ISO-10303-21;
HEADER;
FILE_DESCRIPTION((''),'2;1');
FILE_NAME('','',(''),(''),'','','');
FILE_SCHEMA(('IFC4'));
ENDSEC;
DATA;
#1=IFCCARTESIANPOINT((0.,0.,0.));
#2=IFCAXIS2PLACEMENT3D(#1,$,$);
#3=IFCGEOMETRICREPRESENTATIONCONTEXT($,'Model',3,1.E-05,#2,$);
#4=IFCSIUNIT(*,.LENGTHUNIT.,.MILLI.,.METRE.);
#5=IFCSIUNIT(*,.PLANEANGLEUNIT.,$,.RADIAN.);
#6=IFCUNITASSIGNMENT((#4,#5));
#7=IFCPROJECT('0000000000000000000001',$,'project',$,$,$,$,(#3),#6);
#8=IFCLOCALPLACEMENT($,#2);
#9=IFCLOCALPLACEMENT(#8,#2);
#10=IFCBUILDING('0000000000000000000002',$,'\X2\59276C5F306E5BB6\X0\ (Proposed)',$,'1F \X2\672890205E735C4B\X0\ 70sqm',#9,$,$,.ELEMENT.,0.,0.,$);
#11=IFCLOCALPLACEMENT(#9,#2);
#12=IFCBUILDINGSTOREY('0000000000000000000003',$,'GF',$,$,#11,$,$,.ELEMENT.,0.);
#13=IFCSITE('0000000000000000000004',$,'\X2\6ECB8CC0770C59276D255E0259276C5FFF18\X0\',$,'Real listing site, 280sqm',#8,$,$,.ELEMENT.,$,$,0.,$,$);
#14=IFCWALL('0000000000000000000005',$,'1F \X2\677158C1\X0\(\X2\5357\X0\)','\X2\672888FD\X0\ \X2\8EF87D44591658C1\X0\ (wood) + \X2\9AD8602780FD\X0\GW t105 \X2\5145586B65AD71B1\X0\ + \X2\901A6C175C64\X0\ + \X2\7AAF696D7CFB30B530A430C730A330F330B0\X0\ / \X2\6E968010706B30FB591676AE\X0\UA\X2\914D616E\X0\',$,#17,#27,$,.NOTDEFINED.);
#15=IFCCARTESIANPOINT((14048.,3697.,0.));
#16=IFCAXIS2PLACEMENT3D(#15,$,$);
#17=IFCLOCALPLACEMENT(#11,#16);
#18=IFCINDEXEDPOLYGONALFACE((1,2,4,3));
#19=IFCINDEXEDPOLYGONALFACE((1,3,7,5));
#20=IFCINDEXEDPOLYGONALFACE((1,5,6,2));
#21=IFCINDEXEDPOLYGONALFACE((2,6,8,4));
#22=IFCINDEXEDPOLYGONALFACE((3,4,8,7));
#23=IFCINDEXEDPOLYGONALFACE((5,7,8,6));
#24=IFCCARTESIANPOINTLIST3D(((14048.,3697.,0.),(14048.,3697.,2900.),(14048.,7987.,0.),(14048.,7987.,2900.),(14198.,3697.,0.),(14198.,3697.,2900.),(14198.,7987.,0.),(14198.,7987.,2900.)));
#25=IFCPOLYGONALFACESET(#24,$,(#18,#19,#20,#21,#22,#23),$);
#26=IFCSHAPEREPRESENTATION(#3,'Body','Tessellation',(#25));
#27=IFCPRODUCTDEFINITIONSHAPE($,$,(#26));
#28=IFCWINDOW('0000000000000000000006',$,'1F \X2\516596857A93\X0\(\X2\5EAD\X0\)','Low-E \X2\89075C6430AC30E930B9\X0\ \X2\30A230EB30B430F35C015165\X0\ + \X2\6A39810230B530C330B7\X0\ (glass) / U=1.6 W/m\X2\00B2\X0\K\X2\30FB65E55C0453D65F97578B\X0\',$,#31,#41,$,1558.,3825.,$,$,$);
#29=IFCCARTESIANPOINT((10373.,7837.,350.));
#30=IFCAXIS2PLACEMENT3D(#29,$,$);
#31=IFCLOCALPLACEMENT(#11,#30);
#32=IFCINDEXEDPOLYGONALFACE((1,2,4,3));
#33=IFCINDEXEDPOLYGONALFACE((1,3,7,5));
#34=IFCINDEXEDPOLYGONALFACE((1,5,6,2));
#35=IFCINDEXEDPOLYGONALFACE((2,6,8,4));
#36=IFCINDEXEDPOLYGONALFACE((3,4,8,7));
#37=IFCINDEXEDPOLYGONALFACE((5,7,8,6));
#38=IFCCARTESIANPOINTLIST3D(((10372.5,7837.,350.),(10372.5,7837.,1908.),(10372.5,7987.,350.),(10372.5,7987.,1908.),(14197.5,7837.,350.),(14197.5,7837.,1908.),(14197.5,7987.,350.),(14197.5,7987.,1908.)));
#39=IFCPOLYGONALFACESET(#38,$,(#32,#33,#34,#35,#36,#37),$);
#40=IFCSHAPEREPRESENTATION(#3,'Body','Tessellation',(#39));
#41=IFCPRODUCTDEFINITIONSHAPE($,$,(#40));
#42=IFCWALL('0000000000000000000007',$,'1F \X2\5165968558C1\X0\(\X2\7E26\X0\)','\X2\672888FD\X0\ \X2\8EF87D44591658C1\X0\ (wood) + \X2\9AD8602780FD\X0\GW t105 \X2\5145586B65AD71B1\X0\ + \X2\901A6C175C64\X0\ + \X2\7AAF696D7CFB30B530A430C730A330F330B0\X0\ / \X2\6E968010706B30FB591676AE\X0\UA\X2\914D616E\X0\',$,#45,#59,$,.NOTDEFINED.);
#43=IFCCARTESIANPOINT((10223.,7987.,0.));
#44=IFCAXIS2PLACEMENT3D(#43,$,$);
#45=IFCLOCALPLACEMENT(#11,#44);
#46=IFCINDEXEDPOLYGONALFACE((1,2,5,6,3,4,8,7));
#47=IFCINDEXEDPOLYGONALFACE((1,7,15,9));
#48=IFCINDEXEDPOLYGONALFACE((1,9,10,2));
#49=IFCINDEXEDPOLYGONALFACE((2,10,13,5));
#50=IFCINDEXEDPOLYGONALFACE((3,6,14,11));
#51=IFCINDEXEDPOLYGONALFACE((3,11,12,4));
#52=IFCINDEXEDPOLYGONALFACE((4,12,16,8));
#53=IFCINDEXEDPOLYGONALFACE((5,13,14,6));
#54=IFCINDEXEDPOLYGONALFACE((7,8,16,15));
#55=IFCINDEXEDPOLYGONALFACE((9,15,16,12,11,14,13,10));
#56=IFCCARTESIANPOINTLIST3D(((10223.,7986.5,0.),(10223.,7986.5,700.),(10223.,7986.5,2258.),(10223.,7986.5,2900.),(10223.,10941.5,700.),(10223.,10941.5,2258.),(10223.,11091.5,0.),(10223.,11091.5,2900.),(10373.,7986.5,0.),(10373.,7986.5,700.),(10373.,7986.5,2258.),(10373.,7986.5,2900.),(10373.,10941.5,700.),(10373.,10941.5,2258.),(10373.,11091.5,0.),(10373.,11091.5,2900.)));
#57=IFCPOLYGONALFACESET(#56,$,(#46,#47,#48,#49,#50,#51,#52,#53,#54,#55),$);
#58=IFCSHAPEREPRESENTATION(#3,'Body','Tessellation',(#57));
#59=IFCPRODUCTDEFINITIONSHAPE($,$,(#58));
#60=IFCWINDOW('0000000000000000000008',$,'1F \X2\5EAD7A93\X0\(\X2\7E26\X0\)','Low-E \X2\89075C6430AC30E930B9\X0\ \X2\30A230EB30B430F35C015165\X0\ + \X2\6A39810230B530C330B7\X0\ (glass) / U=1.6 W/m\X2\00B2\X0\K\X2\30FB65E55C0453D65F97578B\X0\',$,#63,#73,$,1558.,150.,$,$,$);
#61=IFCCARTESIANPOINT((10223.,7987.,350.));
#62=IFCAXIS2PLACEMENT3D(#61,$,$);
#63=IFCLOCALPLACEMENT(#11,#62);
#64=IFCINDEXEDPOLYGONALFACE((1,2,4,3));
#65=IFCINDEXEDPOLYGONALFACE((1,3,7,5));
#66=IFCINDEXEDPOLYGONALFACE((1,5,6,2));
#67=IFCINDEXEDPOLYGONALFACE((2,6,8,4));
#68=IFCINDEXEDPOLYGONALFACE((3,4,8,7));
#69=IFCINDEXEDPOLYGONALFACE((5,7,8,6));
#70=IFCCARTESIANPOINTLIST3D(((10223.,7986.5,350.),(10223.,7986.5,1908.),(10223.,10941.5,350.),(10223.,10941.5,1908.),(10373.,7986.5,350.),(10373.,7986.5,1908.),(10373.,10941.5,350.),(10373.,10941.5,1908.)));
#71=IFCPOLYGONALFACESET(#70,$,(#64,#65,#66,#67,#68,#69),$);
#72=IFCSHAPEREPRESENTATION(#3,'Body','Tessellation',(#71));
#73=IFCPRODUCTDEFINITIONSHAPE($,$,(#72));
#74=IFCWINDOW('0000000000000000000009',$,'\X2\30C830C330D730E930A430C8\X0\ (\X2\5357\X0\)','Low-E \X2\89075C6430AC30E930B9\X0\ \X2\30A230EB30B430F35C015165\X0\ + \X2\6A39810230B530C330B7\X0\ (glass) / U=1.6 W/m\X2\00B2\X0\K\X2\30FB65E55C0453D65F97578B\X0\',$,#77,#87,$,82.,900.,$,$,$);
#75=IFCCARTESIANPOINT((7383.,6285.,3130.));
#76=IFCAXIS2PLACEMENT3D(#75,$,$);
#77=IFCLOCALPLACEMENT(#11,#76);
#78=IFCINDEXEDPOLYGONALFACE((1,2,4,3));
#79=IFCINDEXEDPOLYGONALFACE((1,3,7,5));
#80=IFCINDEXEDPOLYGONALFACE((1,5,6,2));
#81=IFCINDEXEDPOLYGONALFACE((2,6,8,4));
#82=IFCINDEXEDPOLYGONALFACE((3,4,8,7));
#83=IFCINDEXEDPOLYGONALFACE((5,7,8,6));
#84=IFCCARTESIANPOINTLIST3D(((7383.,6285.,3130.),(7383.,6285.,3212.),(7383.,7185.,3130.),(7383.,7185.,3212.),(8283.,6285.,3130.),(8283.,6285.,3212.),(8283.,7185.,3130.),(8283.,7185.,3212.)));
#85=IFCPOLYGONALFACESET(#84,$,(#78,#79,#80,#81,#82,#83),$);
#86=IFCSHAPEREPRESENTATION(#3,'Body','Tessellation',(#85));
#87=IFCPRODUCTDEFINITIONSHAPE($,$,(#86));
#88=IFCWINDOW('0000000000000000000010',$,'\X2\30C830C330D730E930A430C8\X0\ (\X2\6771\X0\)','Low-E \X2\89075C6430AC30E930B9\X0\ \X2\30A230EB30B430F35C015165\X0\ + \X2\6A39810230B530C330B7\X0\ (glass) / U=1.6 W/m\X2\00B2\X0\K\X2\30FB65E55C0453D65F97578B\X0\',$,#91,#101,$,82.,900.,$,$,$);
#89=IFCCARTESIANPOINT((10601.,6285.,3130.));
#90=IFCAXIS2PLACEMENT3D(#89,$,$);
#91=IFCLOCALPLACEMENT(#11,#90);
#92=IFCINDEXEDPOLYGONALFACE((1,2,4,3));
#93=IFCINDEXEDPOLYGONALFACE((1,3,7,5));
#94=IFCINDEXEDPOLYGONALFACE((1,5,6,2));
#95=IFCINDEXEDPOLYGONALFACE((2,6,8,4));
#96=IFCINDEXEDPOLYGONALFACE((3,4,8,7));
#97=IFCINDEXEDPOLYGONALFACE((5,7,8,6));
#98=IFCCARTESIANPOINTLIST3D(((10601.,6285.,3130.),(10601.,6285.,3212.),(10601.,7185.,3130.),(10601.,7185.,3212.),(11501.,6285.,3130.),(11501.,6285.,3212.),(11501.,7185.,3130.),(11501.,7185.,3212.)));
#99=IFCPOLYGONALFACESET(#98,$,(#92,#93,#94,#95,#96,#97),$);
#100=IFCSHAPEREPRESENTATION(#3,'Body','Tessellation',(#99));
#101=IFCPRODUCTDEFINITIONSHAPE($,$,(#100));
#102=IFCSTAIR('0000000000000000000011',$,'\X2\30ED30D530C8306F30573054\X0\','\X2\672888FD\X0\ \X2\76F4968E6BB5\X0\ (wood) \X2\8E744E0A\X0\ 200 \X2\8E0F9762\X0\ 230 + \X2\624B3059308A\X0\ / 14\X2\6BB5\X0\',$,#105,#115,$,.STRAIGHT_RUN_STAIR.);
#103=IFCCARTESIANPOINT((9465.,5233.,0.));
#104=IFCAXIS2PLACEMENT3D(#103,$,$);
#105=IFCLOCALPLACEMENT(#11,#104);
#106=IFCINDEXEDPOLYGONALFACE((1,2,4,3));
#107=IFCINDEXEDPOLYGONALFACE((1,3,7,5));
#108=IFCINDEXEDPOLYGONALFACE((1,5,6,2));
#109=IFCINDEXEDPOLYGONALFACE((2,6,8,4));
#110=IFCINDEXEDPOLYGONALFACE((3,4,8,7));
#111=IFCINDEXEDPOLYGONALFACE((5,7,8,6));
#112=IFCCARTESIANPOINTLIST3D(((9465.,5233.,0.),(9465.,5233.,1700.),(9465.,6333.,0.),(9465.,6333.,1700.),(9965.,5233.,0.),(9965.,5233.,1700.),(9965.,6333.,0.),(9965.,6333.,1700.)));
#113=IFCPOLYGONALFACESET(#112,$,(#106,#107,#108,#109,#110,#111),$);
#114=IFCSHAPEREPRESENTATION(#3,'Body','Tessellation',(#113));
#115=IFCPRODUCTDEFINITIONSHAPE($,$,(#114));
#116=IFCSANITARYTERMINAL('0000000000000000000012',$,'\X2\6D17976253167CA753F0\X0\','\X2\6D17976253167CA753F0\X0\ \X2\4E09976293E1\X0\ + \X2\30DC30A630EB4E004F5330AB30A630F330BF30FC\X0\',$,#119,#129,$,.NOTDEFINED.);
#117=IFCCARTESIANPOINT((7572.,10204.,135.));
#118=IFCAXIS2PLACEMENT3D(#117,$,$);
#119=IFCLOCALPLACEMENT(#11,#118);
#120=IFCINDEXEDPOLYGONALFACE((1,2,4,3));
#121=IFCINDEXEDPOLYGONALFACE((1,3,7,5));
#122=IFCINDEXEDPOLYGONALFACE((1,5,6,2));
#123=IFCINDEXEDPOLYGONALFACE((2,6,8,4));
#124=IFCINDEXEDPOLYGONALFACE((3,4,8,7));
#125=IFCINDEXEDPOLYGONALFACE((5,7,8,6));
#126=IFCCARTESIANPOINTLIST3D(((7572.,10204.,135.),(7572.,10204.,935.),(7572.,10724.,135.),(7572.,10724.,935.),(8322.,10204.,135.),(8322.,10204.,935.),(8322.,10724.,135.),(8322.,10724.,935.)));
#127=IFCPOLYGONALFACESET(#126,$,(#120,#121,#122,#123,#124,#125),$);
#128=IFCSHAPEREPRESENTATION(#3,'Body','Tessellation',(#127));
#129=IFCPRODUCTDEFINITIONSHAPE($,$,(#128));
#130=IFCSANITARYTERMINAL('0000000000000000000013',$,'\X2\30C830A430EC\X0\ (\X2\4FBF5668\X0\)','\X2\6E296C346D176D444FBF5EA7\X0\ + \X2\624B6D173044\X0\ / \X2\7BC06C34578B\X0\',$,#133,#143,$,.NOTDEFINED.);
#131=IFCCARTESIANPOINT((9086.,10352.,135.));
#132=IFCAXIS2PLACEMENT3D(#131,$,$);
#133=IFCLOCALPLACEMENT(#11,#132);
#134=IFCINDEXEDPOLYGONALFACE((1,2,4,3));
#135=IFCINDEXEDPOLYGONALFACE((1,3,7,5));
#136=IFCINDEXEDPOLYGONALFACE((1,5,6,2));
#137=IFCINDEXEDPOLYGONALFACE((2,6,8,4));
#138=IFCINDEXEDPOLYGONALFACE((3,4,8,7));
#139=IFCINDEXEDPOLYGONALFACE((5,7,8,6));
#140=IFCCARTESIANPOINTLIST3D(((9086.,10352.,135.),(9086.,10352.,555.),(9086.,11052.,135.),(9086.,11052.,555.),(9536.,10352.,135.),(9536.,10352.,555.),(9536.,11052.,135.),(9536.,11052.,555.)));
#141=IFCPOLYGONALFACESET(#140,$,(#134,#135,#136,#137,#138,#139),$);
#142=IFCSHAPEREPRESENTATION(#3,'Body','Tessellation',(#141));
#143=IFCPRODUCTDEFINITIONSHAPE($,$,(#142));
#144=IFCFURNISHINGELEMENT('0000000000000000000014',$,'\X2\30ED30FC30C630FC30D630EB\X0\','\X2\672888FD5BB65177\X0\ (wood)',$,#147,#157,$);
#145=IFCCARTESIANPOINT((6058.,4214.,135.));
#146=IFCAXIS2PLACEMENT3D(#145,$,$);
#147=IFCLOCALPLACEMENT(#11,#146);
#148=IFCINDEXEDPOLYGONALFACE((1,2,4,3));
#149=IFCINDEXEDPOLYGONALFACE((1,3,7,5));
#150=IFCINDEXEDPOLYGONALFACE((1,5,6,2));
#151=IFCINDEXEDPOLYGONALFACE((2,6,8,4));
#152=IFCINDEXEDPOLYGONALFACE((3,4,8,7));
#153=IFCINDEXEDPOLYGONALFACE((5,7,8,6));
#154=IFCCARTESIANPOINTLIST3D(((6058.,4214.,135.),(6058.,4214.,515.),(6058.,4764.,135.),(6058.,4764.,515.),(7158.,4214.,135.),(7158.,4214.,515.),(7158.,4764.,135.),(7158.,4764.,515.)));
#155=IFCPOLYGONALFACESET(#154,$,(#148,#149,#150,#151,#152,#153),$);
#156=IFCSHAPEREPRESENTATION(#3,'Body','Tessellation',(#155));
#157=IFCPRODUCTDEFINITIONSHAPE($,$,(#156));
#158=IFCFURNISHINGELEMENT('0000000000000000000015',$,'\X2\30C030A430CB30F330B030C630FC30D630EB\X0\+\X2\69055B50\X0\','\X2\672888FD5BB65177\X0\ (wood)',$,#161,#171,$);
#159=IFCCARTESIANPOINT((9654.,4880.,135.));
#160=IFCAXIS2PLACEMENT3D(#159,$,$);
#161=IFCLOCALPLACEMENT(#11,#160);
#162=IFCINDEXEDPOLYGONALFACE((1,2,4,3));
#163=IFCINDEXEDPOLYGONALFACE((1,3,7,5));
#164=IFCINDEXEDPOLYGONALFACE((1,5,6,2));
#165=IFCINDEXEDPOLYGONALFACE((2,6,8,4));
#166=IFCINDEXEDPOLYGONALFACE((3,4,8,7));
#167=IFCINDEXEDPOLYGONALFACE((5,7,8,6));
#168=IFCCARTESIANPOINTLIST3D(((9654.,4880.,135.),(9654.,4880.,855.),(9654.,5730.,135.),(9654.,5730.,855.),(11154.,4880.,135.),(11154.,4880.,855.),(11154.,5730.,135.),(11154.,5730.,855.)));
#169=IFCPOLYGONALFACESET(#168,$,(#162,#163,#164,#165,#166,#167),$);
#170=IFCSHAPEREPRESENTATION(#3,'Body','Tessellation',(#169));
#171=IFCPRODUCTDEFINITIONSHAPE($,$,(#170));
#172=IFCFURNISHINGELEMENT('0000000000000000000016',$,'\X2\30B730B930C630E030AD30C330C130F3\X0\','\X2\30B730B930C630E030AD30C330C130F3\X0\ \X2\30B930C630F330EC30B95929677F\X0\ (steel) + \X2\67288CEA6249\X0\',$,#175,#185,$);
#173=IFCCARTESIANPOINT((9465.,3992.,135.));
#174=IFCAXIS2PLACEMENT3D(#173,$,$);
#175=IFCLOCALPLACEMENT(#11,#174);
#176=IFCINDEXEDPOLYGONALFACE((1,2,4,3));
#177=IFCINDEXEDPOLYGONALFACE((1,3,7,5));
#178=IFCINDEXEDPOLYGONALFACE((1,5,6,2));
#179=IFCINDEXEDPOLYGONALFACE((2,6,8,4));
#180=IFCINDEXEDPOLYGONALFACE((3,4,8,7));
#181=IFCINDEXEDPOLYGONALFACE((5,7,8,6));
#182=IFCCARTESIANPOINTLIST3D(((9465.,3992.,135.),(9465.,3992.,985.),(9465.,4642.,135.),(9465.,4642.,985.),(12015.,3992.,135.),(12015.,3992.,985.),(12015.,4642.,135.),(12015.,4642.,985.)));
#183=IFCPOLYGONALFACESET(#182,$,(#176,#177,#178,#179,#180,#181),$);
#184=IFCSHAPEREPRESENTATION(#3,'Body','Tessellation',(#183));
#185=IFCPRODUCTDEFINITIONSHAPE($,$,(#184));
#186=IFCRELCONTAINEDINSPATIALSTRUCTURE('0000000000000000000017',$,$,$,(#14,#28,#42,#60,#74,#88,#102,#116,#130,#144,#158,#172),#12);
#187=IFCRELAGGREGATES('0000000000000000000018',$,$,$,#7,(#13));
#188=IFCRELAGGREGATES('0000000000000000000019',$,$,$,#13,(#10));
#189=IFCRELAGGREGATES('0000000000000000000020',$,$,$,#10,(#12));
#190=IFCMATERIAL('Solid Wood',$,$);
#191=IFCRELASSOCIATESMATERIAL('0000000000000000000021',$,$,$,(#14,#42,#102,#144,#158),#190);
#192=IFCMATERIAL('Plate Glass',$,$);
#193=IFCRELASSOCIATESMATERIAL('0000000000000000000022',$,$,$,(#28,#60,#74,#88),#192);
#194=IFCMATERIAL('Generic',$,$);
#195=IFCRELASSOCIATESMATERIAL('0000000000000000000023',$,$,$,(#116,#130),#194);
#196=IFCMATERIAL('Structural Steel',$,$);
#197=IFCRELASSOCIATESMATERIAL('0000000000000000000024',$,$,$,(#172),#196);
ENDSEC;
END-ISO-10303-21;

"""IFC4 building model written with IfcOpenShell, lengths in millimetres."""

from ifc_helpers import new_model, si_unit, frame, frame_2d, origin, place, context, project, spatial, rectangle, extrude, material, element, fill, save


model = new_model("IFC4")

# Units and contexts
model_context = context("Model", 3, precision=1e-05, world=origin())
ifc_project = project(units=[si_unit("LENGTHUNIT", "METRE", prefix="MILLI"), si_unit("PLANEANGLEUNIT", "RADIAN")], contexts=[model_context])

# Site, building, storey
site_placement = place(None, origin())
site = spatial("IfcSite", under=ifc_project, at=site_placement, Name="滋賀県大津市大江８", ObjectType="Real listing site, 280sqm", CompositionType="ELEMENT", RefElevation=0.0)
building_placement = place(site_placement, origin())
building = spatial("IfcBuilding", under=site, at=building_placement, Name="大江の家 (Proposed)", ObjectType="1F 木造平屋 70sqm", CompositionType="ELEMENT", ElevationOfRefHeight=0.0, ElevationOfTerrain=0.0)
storey_placement = place(building_placement, origin())
storey = spatial("IfcBuildingStorey", under=building, at=storey_placement, Name="GF", CompositionType="ELEMENT", Elevation=0.0)

# Shared definitions
ifc_material_1 = material(Name="Solid Wood")

# Wall, opening, window
wall_1_placement = place(storey_placement, frame((14048.0, 3697.0, 0.0)))
wall_1 = element("IfcWall", 1, at=wall_1_placement, inside=storey, material=ifc_material_1, Name="1F 東壁(南)", Description="木製 軸組外壁 (wood) + 高性能GW t105 充填断熱 + 通気層 + 窯業系サイディング / 準耐火・外皮UA配慮", PredefinedType="NOTDEFINED", context=model_context, shape_type="SweptSolid", body=[
    extrude(rectangle(XDim=150.0, YDim=4290.0, at=frame_2d((75.0, 2145.0))), frame((14048.0, 3697.0, 0.0)), (0.0, 0.0, 1.0), 2900.0),
])
opening_1_placement = place(storey_placement, frame((10373.0, 7837.0, 350.0)))
opening_1 = element("IfcOpeningElement", 2, at=opening_1_placement, cuts=wall_1, PredefinedType="NOTDEFINED", context=model_context, shape_type="SweptSolid", body=[
    extrude(rectangle(XDim=3825.0, YDim=150.0, at=frame_2d((1912.0, 75.0))), frame((10373.0, 7837.0, 350.0)), (0.0, 0.0, 1.0), 1558.0),
])
ifc_material_2 = material(Name="Plate Glass")
window_1_placement = place(storey_placement, frame((10373.0, 7837.0, 350.0)))
window_1 = element("IfcWindow", 3, at=window_1_placement, inside=storey, material=ifc_material_2, Name="1F 入隅窓(庭)", Description="Low-E 複層ガラス アルゴン封入 + 樹脂サッシ (glass) / U=1.6 W/m²K・日射取得型", OverallHeight=1558.0, OverallWidth=3825.0, context=model_context, shape_type="SweptSolid", body=[
    extrude(rectangle(XDim=3825.0, YDim=150.0, at=frame_2d((1912.0, 75.0))), frame((10373.0, 7837.0, 350.0)), (0.0, 0.0, 1.0), 1558.0),
])
fill(opening_1, window_1)

# Wall, opening, window
wall_2_placement = place(storey_placement, frame((10223.0, 7987.0, 0.0)))
wall_2 = element("IfcWall", 4, at=wall_2_placement, inside=storey, material=ifc_material_1, Name="1F 入隅壁(縦)", Description="木製 軸組外壁 (wood) + 高性能GW t105 充填断熱 + 通気層 + 窯業系サイディング / 準耐火・外皮UA配慮", PredefinedType="NOTDEFINED", context=model_context, shape_type="SweptSolid", body=[
    extrude(rectangle(XDim=150.0, YDim=3105.0, at=frame_2d((75.0, 1552.0))), frame((10223.0, 7987.0, 0.0)), (0.0, 0.0, 1.0), 2900.0),
])
opening_2_placement = place(storey_placement, frame((10223.0, 7987.0, 350.0)))
opening_2 = element("IfcOpeningElement", 5, at=opening_2_placement, cuts=wall_2, PredefinedType="NOTDEFINED", context=model_context, shape_type="SweptSolid", body=[
    extrude(rectangle(XDim=150.0, YDim=2955.0, at=frame_2d((75.0, 1477.0))), frame((10223.0, 7987.0, 350.0)), (0.0, 0.0, 1.0), 1558.0),
])
window_2_placement = place(storey_placement, frame((10223.0, 7987.0, 350.0)))
window_2 = element("IfcWindow", 6, at=window_2_placement, inside=storey, material=ifc_material_2, Name="1F 庭窓(縦)", Description="Low-E 複層ガラス アルゴン封入 + 樹脂サッシ (glass) / U=1.6 W/m²K・日射取得型", OverallHeight=1558.0, OverallWidth=150.0, context=model_context, shape_type="SweptSolid", body=[
    extrude(rectangle(XDim=150.0, YDim=2955.0, at=frame_2d((75.0, 1477.0))), frame((10223.0, 7987.0, 350.0)), (0.0, 0.0, 1.0), 1558.0),
])
fill(opening_2, window_2)

# Windows
window_3_placement = place(storey_placement, frame((7383.0, 6285.0, 3130.0)))
element("IfcWindow", 7, at=window_3_placement, inside=storey, material=ifc_material_2, Name="トップライト (南)", Description="Low-E 複層ガラス アルゴン封入 + 樹脂サッシ (glass) / U=1.6 W/m²K・日射取得型", OverallHeight=82.0, OverallWidth=900.0, context=model_context, shape_type="SweptSolid", body=[
    extrude(rectangle(XDim=900.0, YDim=900.0, at=frame_2d((450.0, 450.0))), frame((7383.0, 6285.0, 3130.0)), (0.0, 0.0, 1.0), 82.0),
])
window_4_placement = place(storey_placement, frame((10601.0, 6285.0, 3130.0)))
element("IfcWindow", 8, at=window_4_placement, inside=storey, material=ifc_material_2, Name="トップライト (東)", Description="Low-E 複層ガラス アルゴン封入 + 樹脂サッシ (glass) / U=1.6 W/m²K・日射取得型", OverallHeight=82.0, OverallWidth=900.0, context=model_context, shape_type="SweptSolid", body=[
    extrude(rectangle(XDim=900.0, YDim=900.0, at=frame_2d((450.0, 450.0))), frame((10601.0, 6285.0, 3130.0)), (0.0, 0.0, 1.0), 82.0),
])

# Stair
stair_placement = place(storey_placement, frame((9465.0, 5233.0, 0.0)))
element("IfcStair", 9, at=stair_placement, inside=storey, material=ifc_material_1, Name="ロフトはしご", Description="木製 直階段 (wood) 蹴上 200 踏面 230 + 手すり / 14段", PredefinedType="STRAIGHT_RUN_STAIR", context=model_context, shape_type="SweptSolid", body=[
    extrude(rectangle(XDim=500.0, YDim=1100.0, at=frame_2d((250.0, 550.0))), frame((9465.0, 5233.0, 0.0)), (0.0, 0.0, 1.0), 1700.0),
])

# Sanitary terminals
ifc_material_3 = material(Name="Generic")
sanitary_terminal_1_placement = place(storey_placement, frame((7572.0, 10204.0, 135.0)))
element("IfcSanitaryTerminal", 10, at=sanitary_terminal_1_placement, inside=storey, material=ifc_material_3, Name="洗面化粧台", Description="洗面化粧台 三面鏡 + ボウル一体カウンター", PredefinedType="NOTDEFINED", context=model_context, shape_type="SweptSolid", body=[
    extrude(rectangle(XDim=750.0, YDim=520.0, at=frame_2d((375.0, 260.0))), frame((7572.0, 10204.0, 135.0)), (0.0, 0.0, 1.0), 800.0),
])
sanitary_terminal_2_placement = place(storey_placement, frame((9086.0, 10352.0, 135.0)))
element("IfcSanitaryTerminal", 11, at=sanitary_terminal_2_placement, inside=storey, material=ifc_material_3, Name="トイレ (便器)", Description="温水洗浄便座 + 手洗い / 節水型", PredefinedType="NOTDEFINED", context=model_context, shape_type="SweptSolid", body=[
    extrude(rectangle(XDim=450.0, YDim=700.0, at=frame_2d((225.0, 350.0))), frame((9086.0, 10352.0, 135.0)), (0.0, 0.0, 1.0), 420.0),
])

# Furnishing elements
furnishing_1_placement = place(storey_placement, frame((6058.0, 4214.0, 135.0)))
element("IfcFurnishingElement", 12, at=furnishing_1_placement, inside=storey, material=ifc_material_1, Name="ローテーブル", Description="木製家具 (wood)", context=model_context, shape_type="SweptSolid", body=[
    extrude(rectangle(XDim=1100.0, YDim=550.0, at=frame_2d((550.0, 275.0))), frame((6058.0, 4214.0, 135.0)), (0.0, 0.0, 1.0), 380.0),
])
furnishing_2_placement = place(storey_placement, frame((9654.0, 4880.0, 135.0)))
element("IfcFurnishingElement", 13, at=furnishing_2_placement, inside=storey, material=ifc_material_1, Name="ダイニングテーブル+椅子", Description="木製家具 (wood)", context=model_context, shape_type="SweptSolid", body=[
    extrude(rectangle(XDim=1500.0, YDim=850.0, at=frame_2d((750.0, 425.0))), frame((9654.0, 4880.0, 135.0)), (0.0, 0.0, 1.0), 720.0),
])
ifc_material_4 = material(Name="Structural Steel")
furnishing_3_placement = place(storey_placement, frame((9465.0, 3992.0, 135.0)))
element("IfcFurnishingElement", 14, at=furnishing_3_placement, inside=storey, material=ifc_material_4, Name="システムキッチン", Description="システムキッチン ステンレス天板 (steel) + 木質扉", context=model_context, shape_type="SweptSolid", body=[
    extrude(rectangle(XDim=2550.0, YDim=650.0, at=frame_2d((1275.0, 325.0))), frame((9465.0, 3992.0, 135.0)), (0.0, 0.0, 1.0), 850.0),
])

save(model, "model.ifc")
